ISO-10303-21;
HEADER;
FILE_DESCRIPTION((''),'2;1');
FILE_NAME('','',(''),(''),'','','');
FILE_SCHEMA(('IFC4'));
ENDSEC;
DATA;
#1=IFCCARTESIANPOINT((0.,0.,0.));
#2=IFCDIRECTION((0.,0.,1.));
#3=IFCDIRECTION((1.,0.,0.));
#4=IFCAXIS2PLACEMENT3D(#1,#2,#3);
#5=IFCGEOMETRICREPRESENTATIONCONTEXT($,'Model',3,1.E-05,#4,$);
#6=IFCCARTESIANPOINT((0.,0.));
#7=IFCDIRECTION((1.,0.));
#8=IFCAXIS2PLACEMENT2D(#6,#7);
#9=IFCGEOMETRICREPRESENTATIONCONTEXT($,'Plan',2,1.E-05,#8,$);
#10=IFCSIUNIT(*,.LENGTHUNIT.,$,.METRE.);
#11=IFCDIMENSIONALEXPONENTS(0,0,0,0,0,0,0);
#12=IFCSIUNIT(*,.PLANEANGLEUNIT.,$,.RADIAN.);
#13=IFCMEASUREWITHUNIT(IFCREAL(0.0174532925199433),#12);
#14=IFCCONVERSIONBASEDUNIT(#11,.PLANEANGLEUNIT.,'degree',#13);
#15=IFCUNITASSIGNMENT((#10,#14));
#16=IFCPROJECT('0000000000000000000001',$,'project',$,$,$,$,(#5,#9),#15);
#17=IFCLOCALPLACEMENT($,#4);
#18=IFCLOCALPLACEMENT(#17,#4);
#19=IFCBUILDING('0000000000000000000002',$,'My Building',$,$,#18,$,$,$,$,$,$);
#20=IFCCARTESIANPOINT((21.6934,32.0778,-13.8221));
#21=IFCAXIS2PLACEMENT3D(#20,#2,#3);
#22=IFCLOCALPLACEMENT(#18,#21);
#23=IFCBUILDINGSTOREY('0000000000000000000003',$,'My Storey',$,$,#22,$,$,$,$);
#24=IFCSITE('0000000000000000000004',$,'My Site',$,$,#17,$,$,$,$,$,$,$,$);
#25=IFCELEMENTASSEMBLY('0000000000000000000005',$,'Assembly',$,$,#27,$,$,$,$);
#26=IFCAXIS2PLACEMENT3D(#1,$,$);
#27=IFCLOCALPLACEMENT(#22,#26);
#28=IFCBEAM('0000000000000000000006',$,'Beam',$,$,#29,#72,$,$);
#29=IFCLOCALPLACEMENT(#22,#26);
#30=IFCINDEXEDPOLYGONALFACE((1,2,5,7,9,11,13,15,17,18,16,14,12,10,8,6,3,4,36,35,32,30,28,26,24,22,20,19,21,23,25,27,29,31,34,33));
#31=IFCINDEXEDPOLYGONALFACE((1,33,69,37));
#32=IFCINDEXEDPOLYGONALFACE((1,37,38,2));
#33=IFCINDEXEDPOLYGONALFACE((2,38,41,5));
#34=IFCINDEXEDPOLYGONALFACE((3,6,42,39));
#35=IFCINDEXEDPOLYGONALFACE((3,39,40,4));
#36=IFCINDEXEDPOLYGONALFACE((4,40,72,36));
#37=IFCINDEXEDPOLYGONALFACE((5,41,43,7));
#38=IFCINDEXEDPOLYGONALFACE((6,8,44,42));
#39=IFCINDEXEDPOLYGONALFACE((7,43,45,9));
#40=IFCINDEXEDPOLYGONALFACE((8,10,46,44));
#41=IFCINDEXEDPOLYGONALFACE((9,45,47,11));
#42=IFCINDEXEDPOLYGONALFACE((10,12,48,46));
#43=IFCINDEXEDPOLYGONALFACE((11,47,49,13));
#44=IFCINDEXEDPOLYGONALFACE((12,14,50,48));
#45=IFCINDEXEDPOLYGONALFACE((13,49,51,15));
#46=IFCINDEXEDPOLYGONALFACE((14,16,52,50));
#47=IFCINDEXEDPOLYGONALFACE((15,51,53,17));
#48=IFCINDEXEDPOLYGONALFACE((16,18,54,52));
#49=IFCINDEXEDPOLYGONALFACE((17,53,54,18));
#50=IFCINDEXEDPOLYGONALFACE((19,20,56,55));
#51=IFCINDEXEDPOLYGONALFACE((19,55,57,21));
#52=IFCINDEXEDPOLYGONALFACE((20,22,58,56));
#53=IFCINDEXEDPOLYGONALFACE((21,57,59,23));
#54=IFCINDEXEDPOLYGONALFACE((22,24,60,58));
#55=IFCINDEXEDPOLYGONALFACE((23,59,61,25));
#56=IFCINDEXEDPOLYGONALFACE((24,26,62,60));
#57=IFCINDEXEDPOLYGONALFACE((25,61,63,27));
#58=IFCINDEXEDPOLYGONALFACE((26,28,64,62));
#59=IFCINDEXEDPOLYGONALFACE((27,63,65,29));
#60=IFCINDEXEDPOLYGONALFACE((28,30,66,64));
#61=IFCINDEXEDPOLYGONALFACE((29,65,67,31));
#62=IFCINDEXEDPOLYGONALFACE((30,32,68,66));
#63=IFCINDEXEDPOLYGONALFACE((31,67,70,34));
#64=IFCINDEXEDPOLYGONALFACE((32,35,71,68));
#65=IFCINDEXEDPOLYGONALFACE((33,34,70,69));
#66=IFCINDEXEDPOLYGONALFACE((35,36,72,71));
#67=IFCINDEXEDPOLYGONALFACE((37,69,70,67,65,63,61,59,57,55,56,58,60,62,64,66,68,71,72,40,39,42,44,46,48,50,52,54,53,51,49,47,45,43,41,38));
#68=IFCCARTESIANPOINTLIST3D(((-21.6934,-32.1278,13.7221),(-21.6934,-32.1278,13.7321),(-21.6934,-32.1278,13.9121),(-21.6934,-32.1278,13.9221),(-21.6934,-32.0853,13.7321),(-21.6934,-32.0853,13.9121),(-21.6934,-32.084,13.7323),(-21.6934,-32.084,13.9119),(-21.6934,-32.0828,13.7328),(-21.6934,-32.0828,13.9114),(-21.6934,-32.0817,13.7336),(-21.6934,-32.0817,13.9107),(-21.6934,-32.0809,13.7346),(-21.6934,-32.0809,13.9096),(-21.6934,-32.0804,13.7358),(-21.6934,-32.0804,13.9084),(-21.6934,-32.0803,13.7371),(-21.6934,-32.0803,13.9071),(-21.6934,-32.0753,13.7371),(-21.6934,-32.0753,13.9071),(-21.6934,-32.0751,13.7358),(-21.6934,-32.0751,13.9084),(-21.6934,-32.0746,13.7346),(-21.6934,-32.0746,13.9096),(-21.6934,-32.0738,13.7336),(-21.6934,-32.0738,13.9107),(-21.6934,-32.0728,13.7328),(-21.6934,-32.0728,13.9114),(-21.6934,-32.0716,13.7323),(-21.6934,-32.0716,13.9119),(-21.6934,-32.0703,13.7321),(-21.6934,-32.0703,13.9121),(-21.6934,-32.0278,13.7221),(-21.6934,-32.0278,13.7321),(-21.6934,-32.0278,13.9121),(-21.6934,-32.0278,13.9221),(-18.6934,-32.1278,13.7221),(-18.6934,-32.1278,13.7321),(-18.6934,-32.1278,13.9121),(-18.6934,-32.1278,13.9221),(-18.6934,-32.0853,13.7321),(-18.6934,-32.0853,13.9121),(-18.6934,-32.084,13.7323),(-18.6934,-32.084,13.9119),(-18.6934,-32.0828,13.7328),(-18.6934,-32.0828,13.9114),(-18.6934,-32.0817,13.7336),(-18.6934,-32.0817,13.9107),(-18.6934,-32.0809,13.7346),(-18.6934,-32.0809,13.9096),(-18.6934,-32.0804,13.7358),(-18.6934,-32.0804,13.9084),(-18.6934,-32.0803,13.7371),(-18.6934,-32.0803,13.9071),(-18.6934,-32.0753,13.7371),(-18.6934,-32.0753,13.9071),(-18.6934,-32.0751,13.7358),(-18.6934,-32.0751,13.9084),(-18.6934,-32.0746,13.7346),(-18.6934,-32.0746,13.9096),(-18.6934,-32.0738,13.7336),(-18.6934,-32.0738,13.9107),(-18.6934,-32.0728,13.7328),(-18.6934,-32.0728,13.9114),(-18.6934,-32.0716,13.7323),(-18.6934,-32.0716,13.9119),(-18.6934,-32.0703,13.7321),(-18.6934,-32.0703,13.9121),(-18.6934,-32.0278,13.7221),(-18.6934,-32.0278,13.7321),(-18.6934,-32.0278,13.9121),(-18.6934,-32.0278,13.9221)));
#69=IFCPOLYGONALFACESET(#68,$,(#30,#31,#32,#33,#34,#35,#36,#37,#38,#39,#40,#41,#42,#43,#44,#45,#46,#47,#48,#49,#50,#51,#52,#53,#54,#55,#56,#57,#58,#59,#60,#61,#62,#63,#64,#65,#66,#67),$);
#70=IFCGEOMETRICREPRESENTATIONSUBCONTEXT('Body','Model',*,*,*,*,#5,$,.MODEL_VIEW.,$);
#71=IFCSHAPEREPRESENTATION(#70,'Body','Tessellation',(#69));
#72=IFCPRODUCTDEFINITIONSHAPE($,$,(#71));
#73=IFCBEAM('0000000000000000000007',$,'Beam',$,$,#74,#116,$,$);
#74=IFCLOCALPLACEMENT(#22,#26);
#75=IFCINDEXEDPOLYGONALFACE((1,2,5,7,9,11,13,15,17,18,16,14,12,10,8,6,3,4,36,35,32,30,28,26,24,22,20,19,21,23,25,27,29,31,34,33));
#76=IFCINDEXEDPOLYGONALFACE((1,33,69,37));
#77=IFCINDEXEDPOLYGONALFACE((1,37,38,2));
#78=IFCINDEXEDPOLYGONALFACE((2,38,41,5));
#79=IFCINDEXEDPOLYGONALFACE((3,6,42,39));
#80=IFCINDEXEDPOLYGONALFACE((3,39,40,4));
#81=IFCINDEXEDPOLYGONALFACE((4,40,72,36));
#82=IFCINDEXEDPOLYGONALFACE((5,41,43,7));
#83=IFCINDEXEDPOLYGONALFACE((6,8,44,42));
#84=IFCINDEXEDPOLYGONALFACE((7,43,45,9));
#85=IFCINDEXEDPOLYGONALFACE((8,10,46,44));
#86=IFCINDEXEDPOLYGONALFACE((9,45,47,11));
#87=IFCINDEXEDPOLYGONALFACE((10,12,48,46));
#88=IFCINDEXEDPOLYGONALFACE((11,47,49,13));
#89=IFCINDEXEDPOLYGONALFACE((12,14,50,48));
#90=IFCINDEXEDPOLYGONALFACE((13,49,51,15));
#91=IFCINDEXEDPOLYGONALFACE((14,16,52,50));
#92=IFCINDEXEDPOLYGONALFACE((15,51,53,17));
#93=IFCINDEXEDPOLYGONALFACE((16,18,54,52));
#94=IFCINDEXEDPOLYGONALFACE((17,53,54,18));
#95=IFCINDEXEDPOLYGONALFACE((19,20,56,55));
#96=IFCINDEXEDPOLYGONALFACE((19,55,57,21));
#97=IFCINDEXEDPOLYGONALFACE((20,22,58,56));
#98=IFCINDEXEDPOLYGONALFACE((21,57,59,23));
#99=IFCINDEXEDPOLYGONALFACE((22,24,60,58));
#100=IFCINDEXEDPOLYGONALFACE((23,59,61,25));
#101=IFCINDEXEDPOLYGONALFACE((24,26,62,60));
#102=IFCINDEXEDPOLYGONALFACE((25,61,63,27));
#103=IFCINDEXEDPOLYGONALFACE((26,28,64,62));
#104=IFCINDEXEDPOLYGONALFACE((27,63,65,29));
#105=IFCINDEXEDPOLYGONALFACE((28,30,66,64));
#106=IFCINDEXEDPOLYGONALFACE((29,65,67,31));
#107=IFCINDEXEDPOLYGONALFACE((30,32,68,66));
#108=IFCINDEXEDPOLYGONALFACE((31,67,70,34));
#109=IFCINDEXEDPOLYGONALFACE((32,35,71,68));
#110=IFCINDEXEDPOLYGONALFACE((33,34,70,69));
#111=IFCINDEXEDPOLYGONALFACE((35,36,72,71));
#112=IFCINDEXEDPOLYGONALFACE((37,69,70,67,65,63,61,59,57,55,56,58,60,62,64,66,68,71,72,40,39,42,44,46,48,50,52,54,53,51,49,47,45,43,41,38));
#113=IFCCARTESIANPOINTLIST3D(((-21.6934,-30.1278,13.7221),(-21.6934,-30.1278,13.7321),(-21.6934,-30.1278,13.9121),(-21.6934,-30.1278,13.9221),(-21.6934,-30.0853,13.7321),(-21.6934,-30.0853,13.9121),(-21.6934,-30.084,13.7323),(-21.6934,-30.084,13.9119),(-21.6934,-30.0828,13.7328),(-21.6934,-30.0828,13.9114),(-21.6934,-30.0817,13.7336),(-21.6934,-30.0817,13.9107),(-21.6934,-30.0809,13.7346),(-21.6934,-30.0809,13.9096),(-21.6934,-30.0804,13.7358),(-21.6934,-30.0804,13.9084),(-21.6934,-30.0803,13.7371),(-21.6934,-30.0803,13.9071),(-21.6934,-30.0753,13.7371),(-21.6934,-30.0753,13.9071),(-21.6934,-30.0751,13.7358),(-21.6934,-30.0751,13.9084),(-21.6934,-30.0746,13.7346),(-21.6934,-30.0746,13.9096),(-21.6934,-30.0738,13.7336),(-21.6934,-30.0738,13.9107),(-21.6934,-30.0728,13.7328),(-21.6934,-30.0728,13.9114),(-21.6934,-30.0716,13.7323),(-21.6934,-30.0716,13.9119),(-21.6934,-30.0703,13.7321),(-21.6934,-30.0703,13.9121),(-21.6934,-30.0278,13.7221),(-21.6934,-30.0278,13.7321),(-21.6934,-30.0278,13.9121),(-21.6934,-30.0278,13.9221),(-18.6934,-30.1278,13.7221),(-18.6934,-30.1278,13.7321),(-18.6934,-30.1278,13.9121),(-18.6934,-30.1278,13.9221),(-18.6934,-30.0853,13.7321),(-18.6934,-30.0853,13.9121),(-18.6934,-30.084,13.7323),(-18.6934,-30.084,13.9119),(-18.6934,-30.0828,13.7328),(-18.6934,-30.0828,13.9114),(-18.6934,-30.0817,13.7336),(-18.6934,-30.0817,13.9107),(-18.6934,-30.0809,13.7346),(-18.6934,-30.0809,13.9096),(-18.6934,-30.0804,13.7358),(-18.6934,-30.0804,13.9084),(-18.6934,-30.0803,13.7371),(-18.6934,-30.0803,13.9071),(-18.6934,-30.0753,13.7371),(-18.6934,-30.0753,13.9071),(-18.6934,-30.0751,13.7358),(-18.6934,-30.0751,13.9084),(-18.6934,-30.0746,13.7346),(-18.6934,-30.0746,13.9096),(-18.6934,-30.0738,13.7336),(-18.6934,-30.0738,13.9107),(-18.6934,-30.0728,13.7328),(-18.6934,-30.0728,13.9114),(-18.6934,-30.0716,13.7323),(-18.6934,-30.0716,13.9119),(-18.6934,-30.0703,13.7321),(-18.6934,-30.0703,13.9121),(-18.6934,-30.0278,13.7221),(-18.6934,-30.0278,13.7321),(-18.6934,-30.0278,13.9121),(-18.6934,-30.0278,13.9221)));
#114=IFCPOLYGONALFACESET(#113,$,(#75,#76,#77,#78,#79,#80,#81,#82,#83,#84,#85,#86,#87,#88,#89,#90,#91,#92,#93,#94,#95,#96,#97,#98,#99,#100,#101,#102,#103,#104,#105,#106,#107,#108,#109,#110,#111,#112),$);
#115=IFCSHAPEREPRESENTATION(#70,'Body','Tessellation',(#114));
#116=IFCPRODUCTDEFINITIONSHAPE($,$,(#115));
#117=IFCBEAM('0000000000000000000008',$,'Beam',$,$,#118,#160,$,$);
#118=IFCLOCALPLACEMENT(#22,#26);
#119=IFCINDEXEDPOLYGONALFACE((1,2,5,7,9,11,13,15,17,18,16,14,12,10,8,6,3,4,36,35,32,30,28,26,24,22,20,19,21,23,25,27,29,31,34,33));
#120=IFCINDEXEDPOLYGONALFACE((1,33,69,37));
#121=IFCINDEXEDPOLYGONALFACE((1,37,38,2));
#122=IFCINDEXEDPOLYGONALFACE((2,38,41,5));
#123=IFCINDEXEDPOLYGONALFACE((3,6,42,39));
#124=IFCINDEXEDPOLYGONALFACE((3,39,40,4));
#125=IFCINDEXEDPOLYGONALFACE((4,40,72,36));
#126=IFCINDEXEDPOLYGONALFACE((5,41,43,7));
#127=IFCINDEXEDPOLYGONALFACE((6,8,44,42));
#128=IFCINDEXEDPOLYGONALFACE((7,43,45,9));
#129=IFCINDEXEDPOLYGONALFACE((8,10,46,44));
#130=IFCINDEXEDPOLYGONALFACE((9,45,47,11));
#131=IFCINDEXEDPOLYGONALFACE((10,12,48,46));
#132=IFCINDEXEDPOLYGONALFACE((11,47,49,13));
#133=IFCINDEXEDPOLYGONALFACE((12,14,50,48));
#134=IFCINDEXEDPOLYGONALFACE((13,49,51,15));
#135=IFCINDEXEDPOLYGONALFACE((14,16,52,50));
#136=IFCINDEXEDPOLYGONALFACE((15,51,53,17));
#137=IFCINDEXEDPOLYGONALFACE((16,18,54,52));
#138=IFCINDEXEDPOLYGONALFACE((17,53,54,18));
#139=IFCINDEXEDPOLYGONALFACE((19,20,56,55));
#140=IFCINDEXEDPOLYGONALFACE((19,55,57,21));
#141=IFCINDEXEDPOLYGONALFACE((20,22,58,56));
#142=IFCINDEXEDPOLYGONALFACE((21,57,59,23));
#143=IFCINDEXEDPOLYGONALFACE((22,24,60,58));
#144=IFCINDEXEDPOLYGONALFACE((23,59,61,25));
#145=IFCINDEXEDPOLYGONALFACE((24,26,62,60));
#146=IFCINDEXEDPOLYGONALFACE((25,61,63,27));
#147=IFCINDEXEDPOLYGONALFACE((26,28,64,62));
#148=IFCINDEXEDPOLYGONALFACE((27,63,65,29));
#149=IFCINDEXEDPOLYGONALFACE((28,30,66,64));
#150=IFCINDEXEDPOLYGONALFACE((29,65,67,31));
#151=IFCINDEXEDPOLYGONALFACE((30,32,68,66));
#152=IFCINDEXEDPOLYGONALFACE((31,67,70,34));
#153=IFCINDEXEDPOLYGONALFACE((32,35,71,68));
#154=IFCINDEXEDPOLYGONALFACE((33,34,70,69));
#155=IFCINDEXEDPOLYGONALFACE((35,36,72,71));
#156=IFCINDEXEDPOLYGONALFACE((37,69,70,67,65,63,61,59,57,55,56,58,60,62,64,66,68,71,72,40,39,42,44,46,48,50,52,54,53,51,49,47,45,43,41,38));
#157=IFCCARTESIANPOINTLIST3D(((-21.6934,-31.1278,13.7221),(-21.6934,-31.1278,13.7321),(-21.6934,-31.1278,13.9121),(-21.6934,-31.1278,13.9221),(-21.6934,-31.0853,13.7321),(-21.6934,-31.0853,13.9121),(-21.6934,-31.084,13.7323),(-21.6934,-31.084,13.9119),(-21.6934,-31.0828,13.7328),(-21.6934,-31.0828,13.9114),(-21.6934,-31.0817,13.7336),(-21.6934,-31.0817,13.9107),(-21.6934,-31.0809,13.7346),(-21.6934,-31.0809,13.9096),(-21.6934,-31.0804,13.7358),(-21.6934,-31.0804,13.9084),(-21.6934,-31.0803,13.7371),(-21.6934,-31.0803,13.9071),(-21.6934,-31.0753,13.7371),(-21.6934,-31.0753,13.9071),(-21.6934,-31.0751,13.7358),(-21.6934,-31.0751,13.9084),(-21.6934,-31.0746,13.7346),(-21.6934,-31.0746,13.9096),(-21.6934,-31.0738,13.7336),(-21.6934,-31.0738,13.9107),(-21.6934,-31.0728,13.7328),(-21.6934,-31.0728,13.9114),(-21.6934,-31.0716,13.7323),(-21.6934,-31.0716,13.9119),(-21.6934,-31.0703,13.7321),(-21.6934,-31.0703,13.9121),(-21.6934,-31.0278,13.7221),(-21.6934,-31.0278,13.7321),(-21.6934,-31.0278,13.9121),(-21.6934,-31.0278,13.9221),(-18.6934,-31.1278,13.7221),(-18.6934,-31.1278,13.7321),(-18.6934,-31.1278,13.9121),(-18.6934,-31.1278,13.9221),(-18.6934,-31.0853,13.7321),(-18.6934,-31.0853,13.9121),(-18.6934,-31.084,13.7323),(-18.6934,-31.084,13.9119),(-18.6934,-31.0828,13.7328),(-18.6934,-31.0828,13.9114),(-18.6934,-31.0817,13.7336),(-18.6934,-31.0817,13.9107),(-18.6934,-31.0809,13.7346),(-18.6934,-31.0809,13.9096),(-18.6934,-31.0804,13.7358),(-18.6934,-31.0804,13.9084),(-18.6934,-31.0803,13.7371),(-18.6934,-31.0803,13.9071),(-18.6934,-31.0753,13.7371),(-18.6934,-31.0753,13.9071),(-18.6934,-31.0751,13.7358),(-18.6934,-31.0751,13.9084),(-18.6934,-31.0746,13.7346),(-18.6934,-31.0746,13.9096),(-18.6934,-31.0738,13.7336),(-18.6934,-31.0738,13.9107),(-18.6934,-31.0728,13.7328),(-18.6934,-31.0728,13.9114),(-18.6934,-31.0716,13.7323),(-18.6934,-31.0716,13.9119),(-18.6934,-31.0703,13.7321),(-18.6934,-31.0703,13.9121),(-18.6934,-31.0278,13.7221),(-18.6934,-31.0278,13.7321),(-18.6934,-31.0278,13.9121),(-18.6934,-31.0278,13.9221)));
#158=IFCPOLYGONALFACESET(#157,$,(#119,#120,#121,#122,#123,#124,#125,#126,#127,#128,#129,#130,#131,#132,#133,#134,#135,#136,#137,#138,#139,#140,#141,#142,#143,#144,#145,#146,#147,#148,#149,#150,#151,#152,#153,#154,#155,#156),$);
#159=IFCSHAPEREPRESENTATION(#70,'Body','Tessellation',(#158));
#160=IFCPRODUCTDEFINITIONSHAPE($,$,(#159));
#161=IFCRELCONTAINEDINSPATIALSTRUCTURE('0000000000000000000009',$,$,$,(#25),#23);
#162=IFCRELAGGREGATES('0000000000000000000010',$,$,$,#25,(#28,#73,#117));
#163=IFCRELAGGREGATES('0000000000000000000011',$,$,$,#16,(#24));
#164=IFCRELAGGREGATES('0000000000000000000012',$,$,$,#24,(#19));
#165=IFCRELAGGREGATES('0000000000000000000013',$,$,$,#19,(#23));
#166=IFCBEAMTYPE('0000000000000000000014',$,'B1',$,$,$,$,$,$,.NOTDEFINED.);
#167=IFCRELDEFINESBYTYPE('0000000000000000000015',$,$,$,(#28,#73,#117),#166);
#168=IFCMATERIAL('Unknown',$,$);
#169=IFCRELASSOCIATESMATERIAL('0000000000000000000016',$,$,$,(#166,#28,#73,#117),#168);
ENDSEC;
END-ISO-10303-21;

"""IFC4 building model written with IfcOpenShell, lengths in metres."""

from ifc_helpers import new_model, entity, si_unit, converted_unit, frame, origin_with_axes, origin_2d_with_axis, place, context, subcontext, project, spatial, i_section, extrude, material, material_profile, profile_set, profile_usage, type_object, element, aggregate, save


model = new_model("IFC4")

# Units and contexts
model_context = context("Model", 3, precision=1e-05, world=origin_with_axes())
plan_context = context("Plan", 2, precision=1e-05, world=origin_2d_with_axis())
body_context = subcontext(model_context, "Body", "Model", "MODEL_VIEW")
ifc_project = project(units=[si_unit("LENGTHUNIT", "METRE"), converted_unit("PLANEANGLEUNIT", "degree", entity("IfcReal", 0.0174532925199433), si_unit("PLANEANGLEUNIT", "RADIAN"), dimensions=[0, 0, 0, 0, 0, 0, 0])], contexts=[model_context, plan_context])

# Site, building, storey
site_placement = place(None, origin_with_axes())
site = spatial("IfcSite", under=ifc_project, at=site_placement, Name="My Site")
building_placement = place(site_placement, origin_with_axes())
building = spatial("IfcBuilding", under=site, at=building_placement, Name="My Building")
storey_placement = place(building_placement, frame((21.6934, 32.0778, -13.8221), z_axis=(0.0, 0.0, 1.0), x_axis=(1.0, 0.0, 0.0)))
storey = spatial("IfcBuildingStorey", under=building, at=storey_placement, Name="My Storey")

# Element assembly, beams
assembly_placement = place(storey_placement, frame((-21.6934, -32.0778, 13.8221), z_axis=(0.0, 0.0, 1.0), x_axis=(1.0, 0.0, 0.0)))
assembly = element("IfcElementAssembly", 1, at=assembly_placement, inside=storey, Name="Assembly")
ifc_material = material(Name="Unknown")
ifc_material_profile = material_profile(ifc_material, i_section(OverallWidth=0.1, OverallDepth=0.2, WebThickness=0.005, FlangeThickness=0.01, FilletRadius=0.005))
ifc_profile_set = profile_set([ifc_material_profile])
ifc_profile_usage_1 = profile_usage(ifc_profile_set, cardinal=5)
beam_type = type_object("IfcBeamType", Name="B1", PredefinedType="NOTDEFINED", material=ifc_profile_set)
beam_1_placement = place(assembly_placement, frame((0.0, 0.0, 0.0), z_axis=(1.0, 0.0, 0.0), x_axis=(0.0, 1.0, 0.0)))
beam_1 = element("IfcBeam", 2, at=beam_1_placement, type_object=beam_type, material=ifc_profile_usage_1, Name="Beam", context=body_context, shape_type="SweptSolid", body=[
    extrude(i_section(OverallWidth=0.1, OverallDepth=0.2, WebThickness=0.005, FlangeThickness=0.01, FilletRadius=0.005), origin_with_axes(), (0.0, 0.0, 1.0), 3.0),
])
ifc_profile_usage_2 = profile_usage(ifc_profile_set, cardinal=5)
beam_2_placement = place(assembly_placement, frame((0.0, 2.0, 0.0), z_axis=(1.0, 0.0, 0.0), x_axis=(0.0, 1.0, 0.0)))
beam_2 = element("IfcBeam", 3, at=beam_2_placement, type_object=beam_type, material=ifc_profile_usage_2, Name="Beam", context=body_context, shape_type="SweptSolid", body=[
    extrude(i_section(OverallWidth=0.1, OverallDepth=0.2, WebThickness=0.005, FlangeThickness=0.01, FilletRadius=0.005), origin_with_axes(), (0.0, 0.0, 1.0), 3.0),
])
ifc_profile_usage_3 = profile_usage(ifc_profile_set, cardinal=5)
beam_3_placement = place(assembly_placement, frame((0.0, 1.0, 0.0), z_axis=(1.0, 0.0, 0.0), x_axis=(0.0, 1.0, 0.0)))
beam_3 = element("IfcBeam", 4, at=beam_3_placement, type_object=beam_type, material=ifc_profile_usage_3, Name="Beam", context=body_context, shape_type="SweptSolid", body=[
    extrude(i_section(OverallWidth=0.1, OverallDepth=0.2, WebThickness=0.005, FlangeThickness=0.01, FilletRadius=0.005), origin_with_axes(), (0.0, 0.0, 1.0), 3.0),
])
aggregate(assembly, [beam_1, beam_2, beam_3])

save(model, "model.ifc")
